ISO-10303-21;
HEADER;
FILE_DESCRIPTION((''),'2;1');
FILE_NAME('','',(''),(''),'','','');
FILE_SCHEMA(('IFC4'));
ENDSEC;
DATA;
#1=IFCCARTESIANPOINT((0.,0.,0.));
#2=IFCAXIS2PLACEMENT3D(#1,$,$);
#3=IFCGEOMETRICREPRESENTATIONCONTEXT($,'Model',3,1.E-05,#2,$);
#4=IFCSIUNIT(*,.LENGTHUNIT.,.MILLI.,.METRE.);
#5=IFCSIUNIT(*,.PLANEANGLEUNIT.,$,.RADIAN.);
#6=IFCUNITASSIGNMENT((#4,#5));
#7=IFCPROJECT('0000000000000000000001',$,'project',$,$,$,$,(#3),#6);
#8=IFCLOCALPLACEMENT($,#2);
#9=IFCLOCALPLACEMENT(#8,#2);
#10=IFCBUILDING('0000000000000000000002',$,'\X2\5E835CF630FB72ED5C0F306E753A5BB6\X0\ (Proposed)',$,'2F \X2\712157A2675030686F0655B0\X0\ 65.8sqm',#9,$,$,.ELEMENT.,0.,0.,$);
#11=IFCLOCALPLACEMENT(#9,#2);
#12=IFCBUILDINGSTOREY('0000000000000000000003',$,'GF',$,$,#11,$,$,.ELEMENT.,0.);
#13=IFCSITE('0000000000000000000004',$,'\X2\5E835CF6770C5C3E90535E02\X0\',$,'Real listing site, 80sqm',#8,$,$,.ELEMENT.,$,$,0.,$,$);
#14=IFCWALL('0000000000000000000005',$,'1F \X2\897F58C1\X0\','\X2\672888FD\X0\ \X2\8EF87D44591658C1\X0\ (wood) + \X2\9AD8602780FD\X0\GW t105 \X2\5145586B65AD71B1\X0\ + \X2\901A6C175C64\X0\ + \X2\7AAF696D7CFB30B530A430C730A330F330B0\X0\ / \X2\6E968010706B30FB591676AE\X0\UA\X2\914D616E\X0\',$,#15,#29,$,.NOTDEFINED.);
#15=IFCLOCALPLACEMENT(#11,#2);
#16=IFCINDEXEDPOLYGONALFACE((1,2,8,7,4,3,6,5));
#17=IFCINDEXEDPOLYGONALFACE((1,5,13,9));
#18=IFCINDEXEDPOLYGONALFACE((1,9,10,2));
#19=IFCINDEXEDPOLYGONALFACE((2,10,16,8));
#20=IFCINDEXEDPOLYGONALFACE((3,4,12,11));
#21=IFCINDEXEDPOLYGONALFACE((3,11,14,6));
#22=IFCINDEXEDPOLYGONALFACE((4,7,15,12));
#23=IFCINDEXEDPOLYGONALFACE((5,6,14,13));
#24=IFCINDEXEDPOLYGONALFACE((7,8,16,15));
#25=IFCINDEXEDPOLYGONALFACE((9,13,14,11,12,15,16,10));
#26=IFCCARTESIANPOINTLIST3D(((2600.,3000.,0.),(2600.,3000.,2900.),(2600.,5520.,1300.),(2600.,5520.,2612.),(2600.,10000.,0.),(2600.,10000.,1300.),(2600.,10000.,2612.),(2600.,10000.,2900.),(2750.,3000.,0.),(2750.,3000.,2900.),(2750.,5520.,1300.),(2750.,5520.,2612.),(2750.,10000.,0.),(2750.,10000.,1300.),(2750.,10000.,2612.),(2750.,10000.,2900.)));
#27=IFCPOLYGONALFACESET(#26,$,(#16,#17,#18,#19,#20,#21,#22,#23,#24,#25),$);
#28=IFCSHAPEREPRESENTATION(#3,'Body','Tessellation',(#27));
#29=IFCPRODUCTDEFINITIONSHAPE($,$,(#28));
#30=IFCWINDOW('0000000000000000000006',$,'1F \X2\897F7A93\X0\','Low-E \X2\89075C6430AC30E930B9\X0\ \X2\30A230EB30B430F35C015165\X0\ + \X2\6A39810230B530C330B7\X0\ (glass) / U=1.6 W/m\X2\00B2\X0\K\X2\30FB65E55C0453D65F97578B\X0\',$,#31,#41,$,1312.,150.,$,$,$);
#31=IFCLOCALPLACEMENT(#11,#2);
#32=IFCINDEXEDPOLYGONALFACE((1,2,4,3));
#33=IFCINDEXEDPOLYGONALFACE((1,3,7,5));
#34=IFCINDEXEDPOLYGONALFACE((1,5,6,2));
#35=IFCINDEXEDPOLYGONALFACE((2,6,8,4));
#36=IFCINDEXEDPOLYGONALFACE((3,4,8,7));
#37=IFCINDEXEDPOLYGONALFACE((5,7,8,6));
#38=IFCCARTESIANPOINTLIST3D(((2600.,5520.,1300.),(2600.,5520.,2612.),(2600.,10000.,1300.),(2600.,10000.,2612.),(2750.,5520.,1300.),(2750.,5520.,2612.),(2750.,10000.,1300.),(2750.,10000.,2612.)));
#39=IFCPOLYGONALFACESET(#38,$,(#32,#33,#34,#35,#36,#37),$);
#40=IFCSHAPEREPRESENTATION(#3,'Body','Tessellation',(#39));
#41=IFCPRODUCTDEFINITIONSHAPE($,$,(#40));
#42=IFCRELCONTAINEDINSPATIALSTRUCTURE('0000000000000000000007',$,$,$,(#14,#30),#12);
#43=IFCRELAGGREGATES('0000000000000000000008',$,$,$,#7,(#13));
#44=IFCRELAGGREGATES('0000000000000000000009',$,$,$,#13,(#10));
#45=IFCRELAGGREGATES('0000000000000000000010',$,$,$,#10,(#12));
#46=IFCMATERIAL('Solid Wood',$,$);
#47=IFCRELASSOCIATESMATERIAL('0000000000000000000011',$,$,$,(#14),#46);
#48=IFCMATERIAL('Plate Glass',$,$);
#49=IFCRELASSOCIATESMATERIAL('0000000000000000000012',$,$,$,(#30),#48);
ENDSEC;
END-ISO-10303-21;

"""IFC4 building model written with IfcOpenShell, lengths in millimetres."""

from ifc_helpers import new_model, si_unit, frame, frame_2d, origin, place, context, project, spatial, rectangle, extrude, material, element, fill, save


model = new_model("IFC4")

# Units and contexts
model_context = context("Model", 3, precision=1e-05, world=origin())
ifc_project = project(units=[si_unit("LENGTHUNIT", "METRE", prefix="MILLI"), si_unit("PLANEANGLEUNIT", "RADIAN")], contexts=[model_context])

# Site, building, storey
site_placement = place(None, origin())
site = spatial("IfcSite", under=ifc_project, at=site_placement, Name="広島県尾道市", ObjectType="Real listing site, 80sqm", CompositionType="ELEMENT", RefElevation=0.0)
building_placement = place(site_placement, origin())
building = spatial("IfcBuilding", under=site, at=building_placement, Name="広島・狭小の町家 (Proposed)", ObjectType="2F 無垢材と漆喰 65.8sqm", CompositionType="ELEMENT", ElevationOfRefHeight=0.0, ElevationOfTerrain=0.0)
storey_placement = place(building_placement, origin())
storey = spatial("IfcBuildingStorey", under=building, at=storey_placement, Name="GF", CompositionType="ELEMENT", Elevation=0.0)

# Shared definitions
ifc_material_1 = material(Name="Solid Wood")

# Shared definitions
ifc_material_2 = material(Name="Plate Glass")

# Wall, opening, window
wall_1_placement = place(storey_placement, frame((1300.0, 1500.0, 0.0)))
wall_1 = element("IfcWall", 1, at=wall_1_placement, inside=storey, material=ifc_material_1, Name="1F 西壁", Description="木製 軸組外壁 (wood) + 高性能GW t105 充填断熱 + 通気層 + 窯業系サイディング / 準耐火・外皮UA配慮", PredefinedType="NOTDEFINED", context=model_context, shape_type="SweptSolid", body=[
    extrude(rectangle(XDim=150.0, YDim=7000.0, at=frame_2d((75.0, 3500.0))), frame((1300.0, 1500.0, 0.0)), (0.0, 0.0, 1.0), 2900.0),
])
opening_1_placement = place(storey_placement, frame((1300.0, 2760.0, 650.0)))
opening_1 = element("IfcOpeningElement", 2, at=opening_1_placement, cuts=wall_1, PredefinedType="NOTDEFINED", context=model_context, shape_type="SweptSolid", body=[
    extrude(rectangle(XDim=150.0, YDim=4480.0, at=frame_2d((75.0, 2240.0))), frame((1300.0, 2760.0, 650.0)), (0.0, 0.0, 1.0), 1312.0),
])
window_1_placement = place(storey_placement, frame((1300.0, 2760.0, 650.0)))
window_1 = element("IfcWindow", 3, at=window_1_placement, inside=storey, material=ifc_material_2, Name="1F 西窓", Description="Low-E 複層ガラス アルゴン封入 + 樹脂サッシ (glass) / U=1.6 W/m²K・日射取得型", OverallHeight=1312.0, OverallWidth=150.0, context=model_context, shape_type="SweptSolid", body=[
    extrude(rectangle(XDim=150.0, YDim=4480.0, at=frame_2d((75.0, 2240.0))), frame((1300.0, 2760.0, 650.0)), (0.0, 0.0, 1.0), 1312.0),
])
fill(opening_1, window_1)

save(model, "model.ifc")
